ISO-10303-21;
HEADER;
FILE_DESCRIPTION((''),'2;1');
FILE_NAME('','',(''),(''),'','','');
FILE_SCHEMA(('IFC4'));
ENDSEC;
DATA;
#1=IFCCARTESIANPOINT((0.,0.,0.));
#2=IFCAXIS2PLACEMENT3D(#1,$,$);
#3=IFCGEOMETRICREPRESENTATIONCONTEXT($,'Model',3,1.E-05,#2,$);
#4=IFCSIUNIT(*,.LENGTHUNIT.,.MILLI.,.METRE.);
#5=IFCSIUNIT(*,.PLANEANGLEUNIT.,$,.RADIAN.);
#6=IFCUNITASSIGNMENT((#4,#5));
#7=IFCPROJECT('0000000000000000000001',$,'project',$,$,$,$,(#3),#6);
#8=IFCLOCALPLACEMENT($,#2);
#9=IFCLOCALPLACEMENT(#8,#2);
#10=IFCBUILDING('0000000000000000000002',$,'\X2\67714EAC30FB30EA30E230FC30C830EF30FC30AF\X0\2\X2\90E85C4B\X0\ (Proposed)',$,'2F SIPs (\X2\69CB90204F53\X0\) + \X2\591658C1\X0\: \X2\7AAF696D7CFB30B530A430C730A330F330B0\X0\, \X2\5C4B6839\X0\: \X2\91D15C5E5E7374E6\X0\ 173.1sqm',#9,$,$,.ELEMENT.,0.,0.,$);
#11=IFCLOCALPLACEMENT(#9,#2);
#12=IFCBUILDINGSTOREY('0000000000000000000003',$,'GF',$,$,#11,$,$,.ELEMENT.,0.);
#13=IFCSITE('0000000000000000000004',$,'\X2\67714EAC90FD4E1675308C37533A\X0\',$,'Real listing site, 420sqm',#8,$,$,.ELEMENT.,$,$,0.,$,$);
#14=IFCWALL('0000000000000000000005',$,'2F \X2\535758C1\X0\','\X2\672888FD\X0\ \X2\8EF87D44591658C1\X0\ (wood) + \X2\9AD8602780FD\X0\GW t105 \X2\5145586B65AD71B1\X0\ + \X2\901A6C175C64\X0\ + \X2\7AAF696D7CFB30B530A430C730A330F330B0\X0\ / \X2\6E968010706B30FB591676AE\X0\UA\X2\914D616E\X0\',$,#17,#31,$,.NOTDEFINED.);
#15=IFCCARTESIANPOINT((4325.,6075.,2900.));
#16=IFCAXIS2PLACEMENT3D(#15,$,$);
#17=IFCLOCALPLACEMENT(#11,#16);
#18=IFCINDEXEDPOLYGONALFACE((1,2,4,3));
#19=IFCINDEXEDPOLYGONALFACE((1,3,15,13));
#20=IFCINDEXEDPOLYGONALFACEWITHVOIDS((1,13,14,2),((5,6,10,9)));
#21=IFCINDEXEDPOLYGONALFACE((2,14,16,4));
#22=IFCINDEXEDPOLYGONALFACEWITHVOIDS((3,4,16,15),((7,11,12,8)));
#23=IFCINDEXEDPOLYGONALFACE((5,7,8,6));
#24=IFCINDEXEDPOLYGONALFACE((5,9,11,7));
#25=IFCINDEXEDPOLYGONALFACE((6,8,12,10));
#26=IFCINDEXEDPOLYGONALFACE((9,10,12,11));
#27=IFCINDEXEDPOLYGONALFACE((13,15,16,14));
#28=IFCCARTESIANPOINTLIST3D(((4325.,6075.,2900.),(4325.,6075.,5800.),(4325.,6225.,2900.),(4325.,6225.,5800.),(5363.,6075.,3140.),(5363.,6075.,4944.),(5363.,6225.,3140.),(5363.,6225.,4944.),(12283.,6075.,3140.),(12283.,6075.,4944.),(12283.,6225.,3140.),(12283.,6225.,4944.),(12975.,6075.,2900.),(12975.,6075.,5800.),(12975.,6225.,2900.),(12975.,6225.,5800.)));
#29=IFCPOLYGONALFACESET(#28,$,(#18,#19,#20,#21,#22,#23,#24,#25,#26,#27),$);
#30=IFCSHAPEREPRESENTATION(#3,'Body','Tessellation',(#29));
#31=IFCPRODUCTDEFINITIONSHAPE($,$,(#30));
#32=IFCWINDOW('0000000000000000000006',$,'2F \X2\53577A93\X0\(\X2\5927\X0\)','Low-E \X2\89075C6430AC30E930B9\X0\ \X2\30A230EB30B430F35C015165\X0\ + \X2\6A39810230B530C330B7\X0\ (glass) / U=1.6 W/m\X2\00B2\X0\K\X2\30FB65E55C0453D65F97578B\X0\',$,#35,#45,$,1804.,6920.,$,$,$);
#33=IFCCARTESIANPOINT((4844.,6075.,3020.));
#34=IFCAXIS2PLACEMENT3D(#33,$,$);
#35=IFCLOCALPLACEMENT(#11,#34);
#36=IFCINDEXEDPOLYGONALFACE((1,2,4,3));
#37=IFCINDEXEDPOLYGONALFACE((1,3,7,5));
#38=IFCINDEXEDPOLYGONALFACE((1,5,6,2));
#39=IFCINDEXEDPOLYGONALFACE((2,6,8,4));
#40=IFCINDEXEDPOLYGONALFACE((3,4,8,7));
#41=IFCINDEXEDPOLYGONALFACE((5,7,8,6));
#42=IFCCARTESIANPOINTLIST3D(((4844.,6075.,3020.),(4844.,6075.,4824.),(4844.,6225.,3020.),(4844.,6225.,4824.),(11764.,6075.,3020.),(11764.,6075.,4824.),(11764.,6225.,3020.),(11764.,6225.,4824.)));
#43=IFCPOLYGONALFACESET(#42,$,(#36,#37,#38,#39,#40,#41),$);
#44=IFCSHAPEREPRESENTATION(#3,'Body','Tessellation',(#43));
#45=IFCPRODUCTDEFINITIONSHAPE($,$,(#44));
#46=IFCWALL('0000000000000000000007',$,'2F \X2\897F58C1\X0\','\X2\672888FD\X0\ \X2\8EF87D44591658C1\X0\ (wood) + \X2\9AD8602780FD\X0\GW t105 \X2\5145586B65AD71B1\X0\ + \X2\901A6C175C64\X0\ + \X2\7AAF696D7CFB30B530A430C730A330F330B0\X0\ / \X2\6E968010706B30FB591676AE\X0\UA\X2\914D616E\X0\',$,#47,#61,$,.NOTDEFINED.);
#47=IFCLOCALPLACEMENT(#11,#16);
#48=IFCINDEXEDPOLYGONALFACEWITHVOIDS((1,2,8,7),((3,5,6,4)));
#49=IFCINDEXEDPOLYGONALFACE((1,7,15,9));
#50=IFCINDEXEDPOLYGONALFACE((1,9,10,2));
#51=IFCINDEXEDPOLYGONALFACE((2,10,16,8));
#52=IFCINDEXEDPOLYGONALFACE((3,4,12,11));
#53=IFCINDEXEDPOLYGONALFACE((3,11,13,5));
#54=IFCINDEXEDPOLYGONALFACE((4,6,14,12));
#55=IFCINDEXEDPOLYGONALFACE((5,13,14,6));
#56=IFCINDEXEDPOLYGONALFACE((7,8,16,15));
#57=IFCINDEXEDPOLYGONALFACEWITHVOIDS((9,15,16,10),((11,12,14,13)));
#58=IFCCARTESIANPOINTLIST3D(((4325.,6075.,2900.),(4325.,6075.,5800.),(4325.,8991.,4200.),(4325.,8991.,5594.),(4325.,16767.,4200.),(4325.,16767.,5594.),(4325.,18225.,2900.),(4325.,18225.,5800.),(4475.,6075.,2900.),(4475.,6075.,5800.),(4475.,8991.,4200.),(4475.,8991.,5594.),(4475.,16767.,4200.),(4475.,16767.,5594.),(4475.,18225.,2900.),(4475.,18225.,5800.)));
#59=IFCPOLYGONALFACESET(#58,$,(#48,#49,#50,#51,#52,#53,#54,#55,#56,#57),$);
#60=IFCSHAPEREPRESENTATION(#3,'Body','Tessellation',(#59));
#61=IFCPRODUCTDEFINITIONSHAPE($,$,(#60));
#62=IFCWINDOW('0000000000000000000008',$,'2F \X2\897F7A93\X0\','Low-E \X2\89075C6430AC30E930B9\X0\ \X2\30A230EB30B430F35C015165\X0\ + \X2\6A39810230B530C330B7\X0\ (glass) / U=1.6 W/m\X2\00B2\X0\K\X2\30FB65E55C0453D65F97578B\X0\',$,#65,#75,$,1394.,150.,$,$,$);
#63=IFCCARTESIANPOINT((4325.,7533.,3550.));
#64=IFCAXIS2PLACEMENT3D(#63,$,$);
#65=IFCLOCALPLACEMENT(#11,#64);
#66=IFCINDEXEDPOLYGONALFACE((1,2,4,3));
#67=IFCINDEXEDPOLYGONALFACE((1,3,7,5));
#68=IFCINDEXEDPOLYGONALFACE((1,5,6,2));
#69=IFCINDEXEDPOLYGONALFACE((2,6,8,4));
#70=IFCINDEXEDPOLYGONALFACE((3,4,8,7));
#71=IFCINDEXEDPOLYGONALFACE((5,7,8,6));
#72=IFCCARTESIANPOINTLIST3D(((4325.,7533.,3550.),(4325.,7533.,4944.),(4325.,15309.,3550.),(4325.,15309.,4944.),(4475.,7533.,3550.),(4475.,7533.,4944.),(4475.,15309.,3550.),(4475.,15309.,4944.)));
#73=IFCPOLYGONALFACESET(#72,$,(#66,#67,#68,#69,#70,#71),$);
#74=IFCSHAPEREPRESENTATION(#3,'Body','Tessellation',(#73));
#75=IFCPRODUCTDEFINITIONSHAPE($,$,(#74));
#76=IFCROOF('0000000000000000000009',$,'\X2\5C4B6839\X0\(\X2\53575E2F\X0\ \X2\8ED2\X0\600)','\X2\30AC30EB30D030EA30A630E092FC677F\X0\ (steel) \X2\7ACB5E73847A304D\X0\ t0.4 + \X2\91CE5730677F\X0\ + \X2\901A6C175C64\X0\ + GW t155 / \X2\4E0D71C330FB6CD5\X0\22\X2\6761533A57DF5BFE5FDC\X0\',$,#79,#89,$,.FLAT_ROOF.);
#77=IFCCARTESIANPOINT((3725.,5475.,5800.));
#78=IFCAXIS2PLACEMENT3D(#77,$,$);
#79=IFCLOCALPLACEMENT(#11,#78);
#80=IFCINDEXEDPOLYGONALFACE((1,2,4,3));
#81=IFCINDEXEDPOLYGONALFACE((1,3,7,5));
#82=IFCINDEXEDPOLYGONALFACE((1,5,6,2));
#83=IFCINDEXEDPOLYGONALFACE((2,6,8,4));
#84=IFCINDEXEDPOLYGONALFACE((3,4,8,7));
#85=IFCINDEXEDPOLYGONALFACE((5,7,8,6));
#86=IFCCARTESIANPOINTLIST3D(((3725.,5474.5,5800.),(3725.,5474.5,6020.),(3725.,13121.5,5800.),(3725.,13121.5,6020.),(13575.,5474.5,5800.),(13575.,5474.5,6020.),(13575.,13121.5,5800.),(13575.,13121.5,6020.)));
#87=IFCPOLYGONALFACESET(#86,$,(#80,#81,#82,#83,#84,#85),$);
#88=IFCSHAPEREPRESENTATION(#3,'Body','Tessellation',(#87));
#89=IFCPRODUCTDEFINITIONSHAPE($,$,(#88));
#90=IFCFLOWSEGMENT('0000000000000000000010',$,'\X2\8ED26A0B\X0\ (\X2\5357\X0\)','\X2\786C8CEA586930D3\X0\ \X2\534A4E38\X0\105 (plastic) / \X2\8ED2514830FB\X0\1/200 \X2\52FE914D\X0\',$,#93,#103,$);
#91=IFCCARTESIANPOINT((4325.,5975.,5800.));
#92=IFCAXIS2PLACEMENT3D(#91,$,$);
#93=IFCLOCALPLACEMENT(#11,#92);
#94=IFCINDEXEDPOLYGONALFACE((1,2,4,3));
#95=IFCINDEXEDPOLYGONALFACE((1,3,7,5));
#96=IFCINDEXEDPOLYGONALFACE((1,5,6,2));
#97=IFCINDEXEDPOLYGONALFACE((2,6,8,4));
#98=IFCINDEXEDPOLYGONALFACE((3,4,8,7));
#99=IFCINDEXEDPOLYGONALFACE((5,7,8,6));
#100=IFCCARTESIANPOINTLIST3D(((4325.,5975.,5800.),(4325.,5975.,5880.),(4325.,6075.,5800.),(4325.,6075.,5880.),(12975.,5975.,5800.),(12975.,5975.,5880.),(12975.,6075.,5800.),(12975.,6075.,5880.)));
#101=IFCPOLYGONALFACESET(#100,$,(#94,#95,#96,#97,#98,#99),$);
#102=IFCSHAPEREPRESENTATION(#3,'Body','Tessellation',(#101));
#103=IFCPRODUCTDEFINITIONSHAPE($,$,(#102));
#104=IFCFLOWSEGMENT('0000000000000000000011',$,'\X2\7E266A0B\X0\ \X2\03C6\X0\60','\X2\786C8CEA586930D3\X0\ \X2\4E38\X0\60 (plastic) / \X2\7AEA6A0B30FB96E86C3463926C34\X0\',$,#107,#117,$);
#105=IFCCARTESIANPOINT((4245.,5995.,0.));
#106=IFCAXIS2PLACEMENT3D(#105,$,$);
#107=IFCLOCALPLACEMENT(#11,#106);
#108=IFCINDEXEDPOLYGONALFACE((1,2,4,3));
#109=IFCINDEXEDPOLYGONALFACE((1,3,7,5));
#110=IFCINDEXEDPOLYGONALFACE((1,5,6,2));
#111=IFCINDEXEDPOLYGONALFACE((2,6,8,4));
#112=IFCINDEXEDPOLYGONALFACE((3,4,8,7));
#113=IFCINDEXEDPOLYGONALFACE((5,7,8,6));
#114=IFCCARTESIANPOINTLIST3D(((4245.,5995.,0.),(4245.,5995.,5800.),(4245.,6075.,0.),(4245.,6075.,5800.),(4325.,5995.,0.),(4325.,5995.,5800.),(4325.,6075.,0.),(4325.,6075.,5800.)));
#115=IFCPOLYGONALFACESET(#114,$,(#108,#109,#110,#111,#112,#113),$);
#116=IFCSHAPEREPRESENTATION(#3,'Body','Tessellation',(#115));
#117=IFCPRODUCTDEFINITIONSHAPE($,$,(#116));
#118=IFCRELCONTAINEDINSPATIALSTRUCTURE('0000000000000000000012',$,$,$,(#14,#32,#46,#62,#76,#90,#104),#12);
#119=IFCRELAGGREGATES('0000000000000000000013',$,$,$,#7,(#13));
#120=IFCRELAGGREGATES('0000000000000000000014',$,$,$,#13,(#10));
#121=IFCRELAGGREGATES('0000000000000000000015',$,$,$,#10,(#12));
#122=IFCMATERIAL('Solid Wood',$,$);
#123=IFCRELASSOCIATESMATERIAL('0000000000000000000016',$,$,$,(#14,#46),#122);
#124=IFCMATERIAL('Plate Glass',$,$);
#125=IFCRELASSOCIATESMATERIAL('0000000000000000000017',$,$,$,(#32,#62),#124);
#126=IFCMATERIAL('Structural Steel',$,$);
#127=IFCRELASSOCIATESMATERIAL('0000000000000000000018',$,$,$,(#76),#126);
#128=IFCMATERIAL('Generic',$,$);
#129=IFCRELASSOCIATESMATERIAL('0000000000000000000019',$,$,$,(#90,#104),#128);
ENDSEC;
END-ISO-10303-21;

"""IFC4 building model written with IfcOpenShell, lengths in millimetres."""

from ifc_helpers import new_model, si_unit, frame, frame_2d, origin, place, context, project, spatial, rectangle, extrude, material, element, fill, save


model = new_model("IFC4")

# Units and contexts
model_context = context("Model", 3, precision=1e-05, world=origin())
ifc_project = project(units=[si_unit("LENGTHUNIT", "METRE", prefix="MILLI"), si_unit("PLANEANGLEUNIT", "RADIAN")], contexts=[model_context])

# Site, building, storey
site_placement = place(None, origin())
site = spatial("IfcSite", under=ifc_project, at=site_placement, Name="東京都世田谷区", ObjectType="Real listing site, 420sqm", CompositionType="ELEMENT", RefElevation=0.0)
building_placement = place(site_placement, origin())
building = spatial("IfcBuilding", under=site, at=building_placement, Name="東京・リモートワーク2部屋 (Proposed)", ObjectType="2F SIPs (構造体) + 外壁: 窯業系サイディング, 屋根: 金属平瓦 173.1sqm", CompositionType="ELEMENT", ElevationOfRefHeight=0.0, ElevationOfTerrain=0.0)
storey_placement = place(building_placement, origin())
storey = spatial("IfcBuildingStorey", under=building, at=storey_placement, Name="GF", CompositionType="ELEMENT", Elevation=0.0)

# Shared definitions
ifc_material_1 = material(Name="Solid Wood")

# Shared definitions
ifc_material_2 = material(Name="Plate Glass")

# Walls, openings, windows
wall_1_placement = place(storey_placement, frame((4325.0, 6075.0, 2900.0)))
wall_1 = element("IfcWall", 1, at=wall_1_placement, inside=storey, material=ifc_material_1, Name="2F 南壁", Description="木製 軸組外壁 (wood) + 高性能GW t105 充填断熱 + 通気層 + 窯業系サイディング / 準耐火・外皮UA配慮", PredefinedType="NOTDEFINED", context=model_context, shape_type="SweptSolid", body=[
    extrude(rectangle(XDim=8650.0, YDim=150.0, at=frame_2d((4325.0, 75.0))), frame((4325.0, 6075.0, 2900.0)), (0.0, 0.0, 1.0), 2900.0),
])
opening_1_placement = place(storey_placement, frame((4844.0, 6075.0, 3020.0)))
opening_1 = element("IfcOpeningElement", 2, at=opening_1_placement, cuts=wall_1, PredefinedType="NOTDEFINED", context=model_context, shape_type="SweptSolid", body=[
    extrude(rectangle(XDim=6920.0, YDim=150.0, at=frame_2d((3460.0, 75.0))), frame((4844.0, 6075.0, 3020.0)), (0.0, 0.0, 1.0), 1804.0),
])
window_1_placement = place(storey_placement, frame((4844.0, 6075.0, 3020.0)))
window_1 = element("IfcWindow", 3, at=window_1_placement, inside=storey, material=ifc_material_2, Name="2F 南窓(大)", Description="Low-E 複層ガラス アルゴン封入 + 樹脂サッシ (glass) / U=1.6 W/m²K・日射取得型", OverallHeight=1804.0, OverallWidth=6920.0, context=model_context, shape_type="SweptSolid", body=[
    extrude(rectangle(XDim=6920.0, YDim=150.0, at=frame_2d((3460.0, 75.0))), frame((4844.0, 6075.0, 3020.0)), (0.0, 0.0, 1.0), 1804.0),
])
fill(opening_1, window_1)
wall_2_placement = place(storey_placement, frame((4325.0, 6075.0, 2900.0)))
wall_2 = element("IfcWall", 4, at=wall_2_placement, inside=storey, material=ifc_material_1, Name="2F 西壁", Description="木製 軸組外壁 (wood) + 高性能GW t105 充填断熱 + 通気層 + 窯業系サイディング / 準耐火・外皮UA配慮", PredefinedType="NOTDEFINED", context=model_context, shape_type="SweptSolid", body=[
    extrude(rectangle(XDim=150.0, YDim=12150.0, at=frame_2d((75.0, 6075.0))), frame((4325.0, 6075.0, 2900.0)), (0.0, 0.0, 1.0), 2900.0),
])
opening_2_placement = place(storey_placement, frame((4325.0, 7533.0, 3550.0)))
opening_2 = element("IfcOpeningElement", 5, at=opening_2_placement, cuts=wall_2, PredefinedType="NOTDEFINED", context=model_context, shape_type="SweptSolid", body=[
    extrude(rectangle(XDim=150.0, YDim=7776.0, at=frame_2d((75.0, 3888.0))), frame((4325.0, 7533.0, 3550.0)), (0.0, 0.0, 1.0), 1394.0),
])
window_2_placement = place(storey_placement, frame((4325.0, 7533.0, 3550.0)))
window_2 = element("IfcWindow", 6, at=window_2_placement, inside=storey, material=ifc_material_2, Name="2F 西窓", Description="Low-E 複層ガラス アルゴン封入 + 樹脂サッシ (glass) / U=1.6 W/m²K・日射取得型", OverallHeight=1394.0, OverallWidth=150.0, context=model_context, shape_type="SweptSolid", body=[
    extrude(rectangle(XDim=150.0, YDim=7776.0, at=frame_2d((75.0, 3888.0))), frame((4325.0, 7533.0, 3550.0)), (0.0, 0.0, 1.0), 1394.0),
])
fill(opening_2, window_2)

# Roof
ifc_material_3 = material(Name="Structural Steel")
for number, where, name in (
    (7, (3725.0, 5475.0, 5800.0), "屋根(南帯 軒600)"),
):
    element("IfcRoof", number, at=place(storey_placement, frame(where)), inside=storey, material=ifc_material_3, Name=name, Description="ガルバリウム鋼板 (steel) 立平葺き t0.4 + 野地板 + 通気層 + GW t155 / 不燃・法22条区域対応", PredefinedType="FLAT_ROOF", context=model_context, shape_type="SweptSolid", body=[
        extrude(rectangle(XDim=9850.0, YDim=7647.0, at=frame_2d((4925.0, 3823.0))), frame((3725.0, 5475.0, 5800.0)), (0.0, 0.0, 1.0), 220.0),
    ])

# Flow segments
ifc_material_4 = material(Name="Generic")
flow_segment_1_placement = place(storey_placement, frame((4325.0, 5975.0, 5800.0)))
element("IfcFlowSegment", 8, at=flow_segment_1_placement, inside=storey, material=ifc_material_4, Name="軒樋 (南)", Description="硬質塩ビ 半丸105 (plastic) / 軒先・1/200 勾配", context=model_context, shape_type="SweptSolid", body=[
    extrude(rectangle(XDim=8650.0, YDim=100.0, at=frame_2d((4325.0, 50.0))), frame((4325.0, 5975.0, 5800.0)), (0.0, 0.0, 1.0), 80.0),
])
flow_segment_2_placement = place(storey_placement, frame((4245.0, 5995.0, 0.0)))
element("IfcFlowSegment", 9, at=flow_segment_2_placement, inside=storey, material=ifc_material_4, Name="縦樋 φ60", Description="硬質塩ビ 丸60 (plastic) / 竪樋・雨水排水", context=model_context, shape_type="SweptSolid", body=[
    extrude(rectangle(XDim=80.0, YDim=80.0, at=frame_2d((40.0, 40.0))), frame((4245.0, 5995.0, 0.0)), (0.0, 0.0, 1.0), 5800.0),
])

save(model, "model.ifc")
